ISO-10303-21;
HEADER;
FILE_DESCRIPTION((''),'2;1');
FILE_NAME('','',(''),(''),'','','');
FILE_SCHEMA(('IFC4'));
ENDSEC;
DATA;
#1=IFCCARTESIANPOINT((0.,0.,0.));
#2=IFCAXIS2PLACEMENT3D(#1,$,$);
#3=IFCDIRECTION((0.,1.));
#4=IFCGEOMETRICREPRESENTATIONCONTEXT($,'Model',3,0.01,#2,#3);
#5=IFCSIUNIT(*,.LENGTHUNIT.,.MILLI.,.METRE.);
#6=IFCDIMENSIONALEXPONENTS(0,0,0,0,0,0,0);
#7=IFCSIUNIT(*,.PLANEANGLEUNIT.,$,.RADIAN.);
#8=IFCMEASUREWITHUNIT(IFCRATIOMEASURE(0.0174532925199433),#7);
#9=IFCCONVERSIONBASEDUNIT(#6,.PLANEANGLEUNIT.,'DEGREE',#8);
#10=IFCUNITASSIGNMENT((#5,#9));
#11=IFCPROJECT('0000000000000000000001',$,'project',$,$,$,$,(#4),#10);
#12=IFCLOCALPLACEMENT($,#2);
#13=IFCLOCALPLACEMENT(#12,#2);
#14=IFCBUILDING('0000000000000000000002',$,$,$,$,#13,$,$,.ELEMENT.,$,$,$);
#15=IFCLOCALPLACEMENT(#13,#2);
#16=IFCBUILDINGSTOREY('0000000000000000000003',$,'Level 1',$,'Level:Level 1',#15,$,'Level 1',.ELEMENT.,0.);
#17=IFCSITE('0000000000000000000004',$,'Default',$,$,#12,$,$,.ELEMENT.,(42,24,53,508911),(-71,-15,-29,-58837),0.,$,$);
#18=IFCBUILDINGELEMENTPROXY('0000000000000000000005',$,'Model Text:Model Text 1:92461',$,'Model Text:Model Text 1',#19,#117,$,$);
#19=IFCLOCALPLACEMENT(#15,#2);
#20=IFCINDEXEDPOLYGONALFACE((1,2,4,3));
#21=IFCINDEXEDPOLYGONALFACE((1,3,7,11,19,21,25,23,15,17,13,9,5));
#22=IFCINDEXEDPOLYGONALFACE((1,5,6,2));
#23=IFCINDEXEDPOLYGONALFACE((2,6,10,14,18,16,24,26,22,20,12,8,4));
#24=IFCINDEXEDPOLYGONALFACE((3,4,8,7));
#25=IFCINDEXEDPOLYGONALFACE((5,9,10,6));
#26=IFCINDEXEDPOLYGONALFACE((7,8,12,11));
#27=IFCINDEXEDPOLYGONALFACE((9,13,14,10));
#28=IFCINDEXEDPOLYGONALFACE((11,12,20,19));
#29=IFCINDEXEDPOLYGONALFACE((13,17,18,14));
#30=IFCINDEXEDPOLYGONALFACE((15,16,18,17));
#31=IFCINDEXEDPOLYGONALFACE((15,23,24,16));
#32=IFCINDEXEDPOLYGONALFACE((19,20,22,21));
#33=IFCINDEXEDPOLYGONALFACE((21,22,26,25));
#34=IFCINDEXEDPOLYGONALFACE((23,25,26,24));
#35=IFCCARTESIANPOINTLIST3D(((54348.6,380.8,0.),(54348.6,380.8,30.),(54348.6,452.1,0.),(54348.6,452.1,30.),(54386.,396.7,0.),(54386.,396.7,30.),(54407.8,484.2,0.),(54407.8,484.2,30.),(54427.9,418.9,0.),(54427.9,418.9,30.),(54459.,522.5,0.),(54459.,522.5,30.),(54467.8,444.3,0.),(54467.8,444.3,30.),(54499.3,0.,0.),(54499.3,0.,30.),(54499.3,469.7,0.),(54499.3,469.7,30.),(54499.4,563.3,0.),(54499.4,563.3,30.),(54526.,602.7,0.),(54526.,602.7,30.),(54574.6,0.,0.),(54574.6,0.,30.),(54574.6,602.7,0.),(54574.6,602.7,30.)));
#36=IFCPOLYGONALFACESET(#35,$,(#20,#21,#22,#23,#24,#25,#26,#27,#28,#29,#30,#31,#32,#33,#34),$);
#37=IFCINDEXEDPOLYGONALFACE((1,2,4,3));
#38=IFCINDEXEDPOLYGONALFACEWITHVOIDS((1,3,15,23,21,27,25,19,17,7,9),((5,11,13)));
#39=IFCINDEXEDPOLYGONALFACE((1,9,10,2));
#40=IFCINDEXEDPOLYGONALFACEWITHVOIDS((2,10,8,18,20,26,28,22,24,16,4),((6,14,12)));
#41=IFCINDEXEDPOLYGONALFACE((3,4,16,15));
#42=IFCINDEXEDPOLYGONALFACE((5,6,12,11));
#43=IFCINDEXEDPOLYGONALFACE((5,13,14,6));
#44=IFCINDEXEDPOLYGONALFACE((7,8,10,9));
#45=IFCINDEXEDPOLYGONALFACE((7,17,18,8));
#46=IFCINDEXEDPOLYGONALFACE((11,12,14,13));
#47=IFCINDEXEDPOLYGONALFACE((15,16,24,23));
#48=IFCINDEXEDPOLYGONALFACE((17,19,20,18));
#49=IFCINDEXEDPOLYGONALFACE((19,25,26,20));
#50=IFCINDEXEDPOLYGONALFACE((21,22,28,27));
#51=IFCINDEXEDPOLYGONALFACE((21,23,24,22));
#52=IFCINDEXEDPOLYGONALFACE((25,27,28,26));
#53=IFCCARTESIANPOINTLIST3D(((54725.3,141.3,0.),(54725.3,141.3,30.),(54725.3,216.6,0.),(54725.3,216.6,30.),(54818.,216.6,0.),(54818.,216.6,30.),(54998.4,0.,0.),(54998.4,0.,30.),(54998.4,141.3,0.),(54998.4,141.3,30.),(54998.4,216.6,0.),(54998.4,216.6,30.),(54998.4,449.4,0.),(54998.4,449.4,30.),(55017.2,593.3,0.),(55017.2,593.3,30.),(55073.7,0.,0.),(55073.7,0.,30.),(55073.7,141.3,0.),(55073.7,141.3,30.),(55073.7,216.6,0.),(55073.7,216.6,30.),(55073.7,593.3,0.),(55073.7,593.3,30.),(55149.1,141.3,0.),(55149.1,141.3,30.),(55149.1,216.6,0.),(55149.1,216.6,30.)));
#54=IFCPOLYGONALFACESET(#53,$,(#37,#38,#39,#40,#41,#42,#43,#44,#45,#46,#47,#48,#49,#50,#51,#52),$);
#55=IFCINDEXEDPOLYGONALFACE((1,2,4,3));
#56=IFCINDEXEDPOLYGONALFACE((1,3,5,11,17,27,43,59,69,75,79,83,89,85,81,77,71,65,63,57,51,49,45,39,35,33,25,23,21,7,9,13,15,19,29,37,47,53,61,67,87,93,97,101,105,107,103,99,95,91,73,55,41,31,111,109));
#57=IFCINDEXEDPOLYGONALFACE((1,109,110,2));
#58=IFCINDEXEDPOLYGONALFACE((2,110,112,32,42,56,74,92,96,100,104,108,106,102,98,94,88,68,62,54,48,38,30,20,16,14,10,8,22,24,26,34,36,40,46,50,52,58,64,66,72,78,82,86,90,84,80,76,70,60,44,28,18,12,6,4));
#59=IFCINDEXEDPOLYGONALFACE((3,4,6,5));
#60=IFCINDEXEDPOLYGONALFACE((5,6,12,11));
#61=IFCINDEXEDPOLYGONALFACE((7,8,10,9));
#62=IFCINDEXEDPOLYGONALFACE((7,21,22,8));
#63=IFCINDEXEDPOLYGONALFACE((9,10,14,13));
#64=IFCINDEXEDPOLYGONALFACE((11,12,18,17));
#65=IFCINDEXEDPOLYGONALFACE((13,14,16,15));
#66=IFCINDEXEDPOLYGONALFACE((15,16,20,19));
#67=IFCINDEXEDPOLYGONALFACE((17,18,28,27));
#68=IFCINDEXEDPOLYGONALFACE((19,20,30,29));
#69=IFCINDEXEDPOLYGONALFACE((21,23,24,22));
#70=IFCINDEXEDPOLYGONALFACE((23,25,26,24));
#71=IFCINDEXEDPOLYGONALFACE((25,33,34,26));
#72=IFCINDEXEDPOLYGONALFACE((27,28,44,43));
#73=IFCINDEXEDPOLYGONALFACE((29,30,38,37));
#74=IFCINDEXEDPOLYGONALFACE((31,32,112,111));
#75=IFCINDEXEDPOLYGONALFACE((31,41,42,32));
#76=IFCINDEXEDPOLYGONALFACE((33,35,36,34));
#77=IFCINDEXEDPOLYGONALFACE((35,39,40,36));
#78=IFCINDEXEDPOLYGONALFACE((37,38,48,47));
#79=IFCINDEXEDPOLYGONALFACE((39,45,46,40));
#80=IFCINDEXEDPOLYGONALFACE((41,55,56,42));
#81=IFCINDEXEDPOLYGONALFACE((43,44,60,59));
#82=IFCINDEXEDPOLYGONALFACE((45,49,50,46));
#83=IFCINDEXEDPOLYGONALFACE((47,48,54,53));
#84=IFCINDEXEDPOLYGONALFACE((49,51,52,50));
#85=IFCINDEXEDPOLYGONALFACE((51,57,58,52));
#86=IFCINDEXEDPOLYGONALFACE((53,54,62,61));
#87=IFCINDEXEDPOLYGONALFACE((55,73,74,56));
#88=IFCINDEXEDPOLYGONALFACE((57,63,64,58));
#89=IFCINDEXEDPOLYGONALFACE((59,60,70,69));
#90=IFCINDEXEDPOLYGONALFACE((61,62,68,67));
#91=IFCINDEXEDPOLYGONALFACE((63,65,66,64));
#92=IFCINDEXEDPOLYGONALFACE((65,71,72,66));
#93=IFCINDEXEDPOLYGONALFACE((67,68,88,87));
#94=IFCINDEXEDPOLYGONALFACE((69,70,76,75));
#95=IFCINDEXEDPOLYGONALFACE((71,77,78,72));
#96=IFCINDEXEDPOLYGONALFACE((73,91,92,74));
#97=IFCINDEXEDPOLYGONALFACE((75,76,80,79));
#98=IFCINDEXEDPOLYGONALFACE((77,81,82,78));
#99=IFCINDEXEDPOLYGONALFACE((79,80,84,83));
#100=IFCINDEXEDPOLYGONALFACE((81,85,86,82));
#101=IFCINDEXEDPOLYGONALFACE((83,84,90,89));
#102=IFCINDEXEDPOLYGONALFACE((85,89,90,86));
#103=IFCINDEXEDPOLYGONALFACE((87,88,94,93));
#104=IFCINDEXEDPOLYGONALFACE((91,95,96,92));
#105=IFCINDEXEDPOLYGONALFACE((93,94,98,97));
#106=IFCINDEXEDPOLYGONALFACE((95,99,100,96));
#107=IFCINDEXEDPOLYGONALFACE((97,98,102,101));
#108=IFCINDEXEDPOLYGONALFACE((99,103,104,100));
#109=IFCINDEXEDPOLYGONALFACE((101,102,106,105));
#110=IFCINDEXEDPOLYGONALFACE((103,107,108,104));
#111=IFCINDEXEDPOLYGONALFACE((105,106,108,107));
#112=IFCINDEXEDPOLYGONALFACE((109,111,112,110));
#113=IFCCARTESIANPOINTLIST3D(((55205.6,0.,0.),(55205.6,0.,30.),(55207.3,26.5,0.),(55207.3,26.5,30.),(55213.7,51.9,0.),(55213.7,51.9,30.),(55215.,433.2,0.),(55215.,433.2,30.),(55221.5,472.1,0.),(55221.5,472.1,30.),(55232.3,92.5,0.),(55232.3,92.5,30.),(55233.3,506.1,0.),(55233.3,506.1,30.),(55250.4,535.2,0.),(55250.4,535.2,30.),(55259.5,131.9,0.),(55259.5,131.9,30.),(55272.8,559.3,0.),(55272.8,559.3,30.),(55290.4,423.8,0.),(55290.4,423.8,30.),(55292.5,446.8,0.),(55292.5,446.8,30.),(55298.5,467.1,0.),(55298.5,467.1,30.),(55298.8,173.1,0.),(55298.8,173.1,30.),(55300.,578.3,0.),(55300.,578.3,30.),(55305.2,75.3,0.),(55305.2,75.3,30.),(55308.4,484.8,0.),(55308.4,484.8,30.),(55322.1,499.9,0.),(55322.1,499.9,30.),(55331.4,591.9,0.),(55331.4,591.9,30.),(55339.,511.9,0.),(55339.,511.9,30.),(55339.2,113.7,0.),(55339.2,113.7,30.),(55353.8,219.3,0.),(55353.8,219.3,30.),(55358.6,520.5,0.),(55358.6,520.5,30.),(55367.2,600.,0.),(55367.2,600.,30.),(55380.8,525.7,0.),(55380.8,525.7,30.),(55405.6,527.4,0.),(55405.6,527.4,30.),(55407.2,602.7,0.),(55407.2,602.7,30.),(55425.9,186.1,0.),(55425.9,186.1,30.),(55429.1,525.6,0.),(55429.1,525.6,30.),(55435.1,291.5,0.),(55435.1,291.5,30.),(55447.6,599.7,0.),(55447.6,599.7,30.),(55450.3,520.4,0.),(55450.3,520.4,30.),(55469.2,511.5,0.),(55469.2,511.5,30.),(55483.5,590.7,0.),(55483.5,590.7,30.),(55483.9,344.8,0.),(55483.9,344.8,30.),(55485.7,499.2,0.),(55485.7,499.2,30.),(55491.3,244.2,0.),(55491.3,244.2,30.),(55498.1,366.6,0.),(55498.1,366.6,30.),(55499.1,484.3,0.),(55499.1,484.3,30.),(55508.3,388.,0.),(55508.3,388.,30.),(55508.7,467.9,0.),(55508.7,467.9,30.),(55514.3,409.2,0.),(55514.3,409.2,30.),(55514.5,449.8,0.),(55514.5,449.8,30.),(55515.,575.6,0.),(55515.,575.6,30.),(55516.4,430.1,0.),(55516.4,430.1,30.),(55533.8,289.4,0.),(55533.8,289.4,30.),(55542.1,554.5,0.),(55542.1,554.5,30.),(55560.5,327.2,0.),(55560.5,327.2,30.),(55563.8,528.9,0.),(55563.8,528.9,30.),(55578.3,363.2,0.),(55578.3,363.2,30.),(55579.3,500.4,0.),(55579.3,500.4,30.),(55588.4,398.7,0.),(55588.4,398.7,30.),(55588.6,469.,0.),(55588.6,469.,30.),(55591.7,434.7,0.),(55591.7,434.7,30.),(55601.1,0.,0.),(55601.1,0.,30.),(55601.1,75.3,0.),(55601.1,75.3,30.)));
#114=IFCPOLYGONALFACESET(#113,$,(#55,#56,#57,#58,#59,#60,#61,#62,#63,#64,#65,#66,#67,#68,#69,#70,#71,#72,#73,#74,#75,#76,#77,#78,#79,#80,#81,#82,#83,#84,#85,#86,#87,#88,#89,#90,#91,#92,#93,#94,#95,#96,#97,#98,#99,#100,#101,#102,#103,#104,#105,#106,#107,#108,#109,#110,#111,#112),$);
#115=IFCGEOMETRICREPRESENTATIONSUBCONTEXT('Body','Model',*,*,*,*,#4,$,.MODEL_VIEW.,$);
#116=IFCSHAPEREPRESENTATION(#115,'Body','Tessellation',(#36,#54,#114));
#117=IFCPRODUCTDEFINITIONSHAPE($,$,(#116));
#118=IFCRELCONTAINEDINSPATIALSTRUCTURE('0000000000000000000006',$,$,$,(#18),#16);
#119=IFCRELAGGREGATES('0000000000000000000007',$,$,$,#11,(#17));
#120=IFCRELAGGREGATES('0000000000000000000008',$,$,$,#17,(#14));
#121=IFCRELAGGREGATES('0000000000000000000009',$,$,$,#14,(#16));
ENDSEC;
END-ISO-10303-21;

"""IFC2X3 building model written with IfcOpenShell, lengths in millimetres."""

from ifc_helpers import new_model, entity, si_unit, converted_unit, direction, frame, origin, place, context, subcontext, project, spatial, polyline, outline, extrude, element, save


model = new_model("IFC2X3")

# Units and contexts
model_context = context("Model", 3, precision=0.01, world=origin(), true_north=direction((0.0, 1.0)))
body_context = subcontext(model_context, "Body", "Model", "MODEL_VIEW")
ifc_project = project(units=[si_unit("LENGTHUNIT", "METRE", prefix="MILLI"), converted_unit("PLANEANGLEUNIT", "DEGREE", entity("IfcRatioMeasure", 0.0174532925199433), si_unit("PLANEANGLEUNIT", "RADIAN"), dimensions=[0, 0, 0, 0, 0, 0, 0])], contexts=[model_context])

# Site, building, storey
site_placement = place(None, origin())
site = spatial("IfcSite", under=ifc_project, at=site_placement, Name="Default", CompositionType="ELEMENT", RefLatitude=(42, 24, 53, 508911), RefLongitude=(-71, -15, -29, -58837), RefElevation=0.0)
building_placement = place(site_placement, origin())
building = spatial("IfcBuilding", under=site, at=building_placement, CompositionType="ELEMENT")
storey_placement = place(building_placement, origin())
storey = spatial("IfcBuildingStorey", under=building, at=storey_placement, Name="Level 1", ObjectType="Level:Level 1", LongName="Level 1", CompositionType="ELEMENT", Elevation=0.0)

# Building element proxy
proxy_1_placement = place(storey_placement, origin())
element("IfcBuildingElementProxy", 1, at=proxy_1_placement, inside=storey, Name="Model Text:Model Text 1:92461", ObjectType="Model Text:Model Text 1", context=body_context, shape_type="SweptSolid", body=[
    extrude(outline(polyline([(-410.6, -111.6), (192.1, -111.6), (192.1, -63.1), (152.7, -36.4), (111.9, 4.0), (73.6, 55.2), (41.4, 114.4), (-29.8, 114.4), (-13.9, 77.0), (8.3, 35.1), (33.7, -4.8), (59.1, -36.3), (-410.6, -36.3), (-410.6, -111.6)])), frame((54463.0, 410.6, 0.0), z_axis=(0.0, 0.0, 1.0), x_axis=(0.0, 1.0, 0.0)), (0.0, 0.0, 1.0), 30.0),
    extrude(outline(polyline([(-6.8, -218.3), (68.5, -218.3), (68.5, -77.1), (143.8, -77.1), (143.8, -1.7), (68.5, -1.7), (68.5, 375.0), (12.0, 375.0), (-280.0, -1.7), (-280.0, -77.1), (-6.8, -77.1), (-6.8, -218.3)]), holes=[polyline([(-6.8, -1.7), (-187.3, -1.7), (-6.8, 231.1), (-6.8, -1.7)])]), frame((55005.3, 218.3, 0.0)), (0.0, 0.0, 1.0), 30.0),
    extrude(outline(polyline([(-190.2, -317.5), (-190.2, -392.8), (205.4, -392.8), (203.7, -366.3), (197.3, -340.9), (178.7, -300.3), (151.5, -260.9), (112.2, -219.7), (57.2, -173.6), (-24.1, -101.3), (-72.9, -48.0), (-87.1, -26.3), (-97.3, -4.8), (-103.4, 16.4), (-105.4, 37.3), (-103.5, 57.0), (-97.7, 75.0), (-88.2, 91.5), (-74.7, 106.4), (-58.2, 118.7), (-39.4, 127.5), (-18.2, 132.8), (5.4, 134.6), (30.2, 132.9), (52.4, 127.7), (72.0, 119.1), (88.9, 107.1), (102.6, 92.0), (112.5, 74.3), (118.5, 54.0), (120.6, 31.0), (196.0, 40.4), (189.5, 79.3), (177.7, 113.3), (160.6, 142.4), (138.2, 166.5), (111.0, 185.5), (79.5, 199.1), (43.8, 207.2), (3.8, 209.9), (-36.6, 206.9), (-72.5, 197.9), (-104.0, 182.8), (-131.1, 161.7), (-152.8, 136.1), (-168.3, 107.6), (-177.6, 76.2), (-180.8, 41.9), (-177.4, 5.8), (-167.4, -29.6), (-149.5, -65.6), (-122.8, -103.4), (-80.3, -148.6), (-14.9, -206.7), (71.8, -279.1), (105.8, -317.5), (-190.2, -317.5)])), frame((55411.0, 392.8, 0.0), z_axis=(0.0, 0.0, -1.0), x_axis=(-1.0, 0.0, 0.0)), (0.0, 0.0, -1.0), 30.0),
])

save(model, "model.ifc")
